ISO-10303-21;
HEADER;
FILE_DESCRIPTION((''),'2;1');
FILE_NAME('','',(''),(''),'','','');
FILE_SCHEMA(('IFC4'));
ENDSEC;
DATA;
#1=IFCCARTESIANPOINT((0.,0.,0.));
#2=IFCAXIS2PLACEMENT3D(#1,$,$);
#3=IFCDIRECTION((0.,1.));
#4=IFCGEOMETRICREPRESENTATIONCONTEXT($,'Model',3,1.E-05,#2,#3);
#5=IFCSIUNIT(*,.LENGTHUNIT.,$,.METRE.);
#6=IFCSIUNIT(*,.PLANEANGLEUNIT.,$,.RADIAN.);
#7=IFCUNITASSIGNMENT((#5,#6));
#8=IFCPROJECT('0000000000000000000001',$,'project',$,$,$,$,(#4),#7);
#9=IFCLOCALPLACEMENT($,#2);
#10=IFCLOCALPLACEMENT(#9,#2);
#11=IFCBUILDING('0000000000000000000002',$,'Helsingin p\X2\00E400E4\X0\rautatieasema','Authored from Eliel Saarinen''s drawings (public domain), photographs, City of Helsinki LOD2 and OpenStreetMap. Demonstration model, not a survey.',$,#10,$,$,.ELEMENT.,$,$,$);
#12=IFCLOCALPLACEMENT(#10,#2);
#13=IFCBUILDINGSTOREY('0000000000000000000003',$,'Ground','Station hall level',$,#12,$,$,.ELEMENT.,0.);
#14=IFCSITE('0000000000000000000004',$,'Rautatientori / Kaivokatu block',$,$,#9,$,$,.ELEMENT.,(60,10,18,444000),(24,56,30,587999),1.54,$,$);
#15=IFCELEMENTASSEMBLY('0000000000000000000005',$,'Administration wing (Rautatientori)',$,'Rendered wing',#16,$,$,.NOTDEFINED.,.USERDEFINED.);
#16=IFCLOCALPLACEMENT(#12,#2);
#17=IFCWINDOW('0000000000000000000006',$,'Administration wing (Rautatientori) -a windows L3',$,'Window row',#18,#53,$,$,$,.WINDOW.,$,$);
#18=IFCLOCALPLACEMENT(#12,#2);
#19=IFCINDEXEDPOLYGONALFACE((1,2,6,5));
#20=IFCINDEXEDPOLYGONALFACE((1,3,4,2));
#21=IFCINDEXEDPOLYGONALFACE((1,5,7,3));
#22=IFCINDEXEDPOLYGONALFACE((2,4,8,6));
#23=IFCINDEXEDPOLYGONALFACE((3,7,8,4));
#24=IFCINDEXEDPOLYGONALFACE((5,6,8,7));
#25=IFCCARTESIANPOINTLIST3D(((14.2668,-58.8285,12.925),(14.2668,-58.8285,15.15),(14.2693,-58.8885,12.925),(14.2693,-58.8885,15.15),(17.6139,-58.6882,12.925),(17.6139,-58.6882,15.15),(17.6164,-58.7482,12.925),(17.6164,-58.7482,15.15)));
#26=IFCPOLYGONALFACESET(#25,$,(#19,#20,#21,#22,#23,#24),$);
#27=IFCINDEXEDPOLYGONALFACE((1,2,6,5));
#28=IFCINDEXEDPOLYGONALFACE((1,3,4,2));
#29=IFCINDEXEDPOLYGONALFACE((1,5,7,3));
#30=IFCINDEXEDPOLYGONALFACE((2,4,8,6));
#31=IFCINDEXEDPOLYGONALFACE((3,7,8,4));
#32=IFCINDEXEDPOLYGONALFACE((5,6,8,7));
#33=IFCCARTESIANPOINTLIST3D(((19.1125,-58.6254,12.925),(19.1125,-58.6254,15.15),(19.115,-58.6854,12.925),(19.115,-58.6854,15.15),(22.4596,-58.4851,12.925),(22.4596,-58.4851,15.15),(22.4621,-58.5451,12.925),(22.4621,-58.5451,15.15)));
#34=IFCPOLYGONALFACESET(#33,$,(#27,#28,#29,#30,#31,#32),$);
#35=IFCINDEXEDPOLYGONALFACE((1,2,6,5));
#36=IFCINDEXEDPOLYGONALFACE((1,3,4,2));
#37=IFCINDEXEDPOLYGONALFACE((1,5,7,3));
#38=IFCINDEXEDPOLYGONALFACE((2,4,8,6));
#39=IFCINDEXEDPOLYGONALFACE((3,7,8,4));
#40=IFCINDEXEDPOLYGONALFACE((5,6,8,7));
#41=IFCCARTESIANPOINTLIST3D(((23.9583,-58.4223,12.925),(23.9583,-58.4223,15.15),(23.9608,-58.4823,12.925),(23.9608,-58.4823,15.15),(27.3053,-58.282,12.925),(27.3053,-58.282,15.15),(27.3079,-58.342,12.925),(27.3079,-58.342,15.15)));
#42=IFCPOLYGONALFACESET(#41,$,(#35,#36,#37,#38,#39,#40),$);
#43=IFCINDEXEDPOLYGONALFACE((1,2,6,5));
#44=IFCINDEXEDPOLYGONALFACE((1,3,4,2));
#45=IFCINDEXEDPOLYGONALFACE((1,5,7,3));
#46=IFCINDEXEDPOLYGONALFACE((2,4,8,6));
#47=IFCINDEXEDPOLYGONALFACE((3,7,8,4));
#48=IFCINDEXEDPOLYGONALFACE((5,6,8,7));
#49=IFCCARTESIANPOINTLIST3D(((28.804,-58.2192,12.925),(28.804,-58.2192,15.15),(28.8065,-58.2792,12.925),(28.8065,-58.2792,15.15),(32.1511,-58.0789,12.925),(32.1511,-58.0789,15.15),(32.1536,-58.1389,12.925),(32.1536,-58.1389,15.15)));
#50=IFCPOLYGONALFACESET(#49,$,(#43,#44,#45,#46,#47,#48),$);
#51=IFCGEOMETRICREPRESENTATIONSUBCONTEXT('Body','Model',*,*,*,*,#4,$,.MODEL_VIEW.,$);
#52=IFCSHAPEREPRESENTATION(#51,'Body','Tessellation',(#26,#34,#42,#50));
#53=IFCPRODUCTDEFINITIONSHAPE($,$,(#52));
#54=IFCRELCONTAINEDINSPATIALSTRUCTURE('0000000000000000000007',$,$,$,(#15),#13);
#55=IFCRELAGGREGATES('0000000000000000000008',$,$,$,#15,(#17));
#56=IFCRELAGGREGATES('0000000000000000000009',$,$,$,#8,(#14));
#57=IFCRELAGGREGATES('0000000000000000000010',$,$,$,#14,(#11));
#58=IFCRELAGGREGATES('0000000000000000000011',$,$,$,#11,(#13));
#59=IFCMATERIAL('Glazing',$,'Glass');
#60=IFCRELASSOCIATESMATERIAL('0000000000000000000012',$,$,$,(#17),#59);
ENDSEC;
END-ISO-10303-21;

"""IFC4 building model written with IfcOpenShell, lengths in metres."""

from ifc_helpers import new_model, si_unit, direction, frame, frame_2d, origin, place, context, subcontext, project, spatial, rectangle, extrude, material, element, aggregate, save


model = new_model("IFC4")

# Units and contexts
model_context = context("Model", 3, precision=1e-05, world=origin(), true_north=direction((0.0, 1.0)))
body_context = subcontext(model_context, "Body", "Model", "MODEL_VIEW")
ifc_project = project(units=[si_unit("LENGTHUNIT", "METRE"), si_unit("PLANEANGLEUNIT", "RADIAN")], contexts=[model_context])

# Site, building, storey
site_placement = place(None, origin())
site = spatial("IfcSite", under=ifc_project, at=site_placement, Name="Rautatientori / Kaivokatu block", CompositionType="ELEMENT", RefLatitude=(60, 10, 18, 444000), RefLongitude=(24, 56, 30, 587999), RefElevation=1.54)
building_placement = place(site_placement, origin())
building = spatial("IfcBuilding", under=site, at=building_placement, Name="Helsingin päärautatieasema", Description="Authored from Eliel Saarinen's drawings (public domain), photographs, City of Helsinki LOD2 and OpenStreetMap. Demonstration model, not a survey.", CompositionType="ELEMENT")
storey_placement = place(building_placement, origin())
storey = spatial("IfcBuildingStorey", under=building, at=storey_placement, Name="Ground", Description="Station hall level", CompositionType="ELEMENT", Elevation=0.0)

# Element assembly, window
assembly_placement = place(building_placement, origin())
assembly = element("IfcElementAssembly", 1, at=assembly_placement, inside=storey, Name="Administration wing (Rautatientori)", ObjectType="Rendered wing", AssemblyPlace="NOTDEFINED", PredefinedType="USERDEFINED")
ifc_material_1 = material(Name="Glazing", Category="Glass")
window_1_placement = place(building_placement, origin())
window_1 = element("IfcWindow", 2, at=window_1_placement, material=ifc_material_1, Name="Administration wing (Rautatientori) -a windows L3", ObjectType="Window row", PredefinedType="WINDOW", context=body_context, shape_type="SweptSolid", body=[
    extrude(rectangle(XDim=3.35, YDim=0.06, at=frame_2d((0.0, 0.0), x_axis=(0.999123, 0.041876))), frame((15.9416, -58.7883, 12.925)), (0.0, 0.0, 1.0), 2.225),
    extrude(rectangle(XDim=3.35, YDim=0.06, at=frame_2d((0.0, 0.0), x_axis=(0.999123, 0.041876))), frame((20.7873, -58.5853, 12.925)), (0.0, 0.0, 1.0), 2.225),
    extrude(rectangle(XDim=3.35, YDim=0.06, at=frame_2d((0.0, 0.0), x_axis=(0.999123, 0.041876))), frame((25.6331, -58.3822, 12.925)), (0.0, 0.0, 1.0), 2.225),
    extrude(rectangle(XDim=3.35, YDim=0.06, at=frame_2d((0.0, 0.0), x_axis=(0.999123, 0.041876))), frame((30.4788, -58.1791, 12.925)), (0.0, 0.0, 1.0), 2.225),
])
aggregate(assembly, [window_1])

save(model, "model.ifc")
